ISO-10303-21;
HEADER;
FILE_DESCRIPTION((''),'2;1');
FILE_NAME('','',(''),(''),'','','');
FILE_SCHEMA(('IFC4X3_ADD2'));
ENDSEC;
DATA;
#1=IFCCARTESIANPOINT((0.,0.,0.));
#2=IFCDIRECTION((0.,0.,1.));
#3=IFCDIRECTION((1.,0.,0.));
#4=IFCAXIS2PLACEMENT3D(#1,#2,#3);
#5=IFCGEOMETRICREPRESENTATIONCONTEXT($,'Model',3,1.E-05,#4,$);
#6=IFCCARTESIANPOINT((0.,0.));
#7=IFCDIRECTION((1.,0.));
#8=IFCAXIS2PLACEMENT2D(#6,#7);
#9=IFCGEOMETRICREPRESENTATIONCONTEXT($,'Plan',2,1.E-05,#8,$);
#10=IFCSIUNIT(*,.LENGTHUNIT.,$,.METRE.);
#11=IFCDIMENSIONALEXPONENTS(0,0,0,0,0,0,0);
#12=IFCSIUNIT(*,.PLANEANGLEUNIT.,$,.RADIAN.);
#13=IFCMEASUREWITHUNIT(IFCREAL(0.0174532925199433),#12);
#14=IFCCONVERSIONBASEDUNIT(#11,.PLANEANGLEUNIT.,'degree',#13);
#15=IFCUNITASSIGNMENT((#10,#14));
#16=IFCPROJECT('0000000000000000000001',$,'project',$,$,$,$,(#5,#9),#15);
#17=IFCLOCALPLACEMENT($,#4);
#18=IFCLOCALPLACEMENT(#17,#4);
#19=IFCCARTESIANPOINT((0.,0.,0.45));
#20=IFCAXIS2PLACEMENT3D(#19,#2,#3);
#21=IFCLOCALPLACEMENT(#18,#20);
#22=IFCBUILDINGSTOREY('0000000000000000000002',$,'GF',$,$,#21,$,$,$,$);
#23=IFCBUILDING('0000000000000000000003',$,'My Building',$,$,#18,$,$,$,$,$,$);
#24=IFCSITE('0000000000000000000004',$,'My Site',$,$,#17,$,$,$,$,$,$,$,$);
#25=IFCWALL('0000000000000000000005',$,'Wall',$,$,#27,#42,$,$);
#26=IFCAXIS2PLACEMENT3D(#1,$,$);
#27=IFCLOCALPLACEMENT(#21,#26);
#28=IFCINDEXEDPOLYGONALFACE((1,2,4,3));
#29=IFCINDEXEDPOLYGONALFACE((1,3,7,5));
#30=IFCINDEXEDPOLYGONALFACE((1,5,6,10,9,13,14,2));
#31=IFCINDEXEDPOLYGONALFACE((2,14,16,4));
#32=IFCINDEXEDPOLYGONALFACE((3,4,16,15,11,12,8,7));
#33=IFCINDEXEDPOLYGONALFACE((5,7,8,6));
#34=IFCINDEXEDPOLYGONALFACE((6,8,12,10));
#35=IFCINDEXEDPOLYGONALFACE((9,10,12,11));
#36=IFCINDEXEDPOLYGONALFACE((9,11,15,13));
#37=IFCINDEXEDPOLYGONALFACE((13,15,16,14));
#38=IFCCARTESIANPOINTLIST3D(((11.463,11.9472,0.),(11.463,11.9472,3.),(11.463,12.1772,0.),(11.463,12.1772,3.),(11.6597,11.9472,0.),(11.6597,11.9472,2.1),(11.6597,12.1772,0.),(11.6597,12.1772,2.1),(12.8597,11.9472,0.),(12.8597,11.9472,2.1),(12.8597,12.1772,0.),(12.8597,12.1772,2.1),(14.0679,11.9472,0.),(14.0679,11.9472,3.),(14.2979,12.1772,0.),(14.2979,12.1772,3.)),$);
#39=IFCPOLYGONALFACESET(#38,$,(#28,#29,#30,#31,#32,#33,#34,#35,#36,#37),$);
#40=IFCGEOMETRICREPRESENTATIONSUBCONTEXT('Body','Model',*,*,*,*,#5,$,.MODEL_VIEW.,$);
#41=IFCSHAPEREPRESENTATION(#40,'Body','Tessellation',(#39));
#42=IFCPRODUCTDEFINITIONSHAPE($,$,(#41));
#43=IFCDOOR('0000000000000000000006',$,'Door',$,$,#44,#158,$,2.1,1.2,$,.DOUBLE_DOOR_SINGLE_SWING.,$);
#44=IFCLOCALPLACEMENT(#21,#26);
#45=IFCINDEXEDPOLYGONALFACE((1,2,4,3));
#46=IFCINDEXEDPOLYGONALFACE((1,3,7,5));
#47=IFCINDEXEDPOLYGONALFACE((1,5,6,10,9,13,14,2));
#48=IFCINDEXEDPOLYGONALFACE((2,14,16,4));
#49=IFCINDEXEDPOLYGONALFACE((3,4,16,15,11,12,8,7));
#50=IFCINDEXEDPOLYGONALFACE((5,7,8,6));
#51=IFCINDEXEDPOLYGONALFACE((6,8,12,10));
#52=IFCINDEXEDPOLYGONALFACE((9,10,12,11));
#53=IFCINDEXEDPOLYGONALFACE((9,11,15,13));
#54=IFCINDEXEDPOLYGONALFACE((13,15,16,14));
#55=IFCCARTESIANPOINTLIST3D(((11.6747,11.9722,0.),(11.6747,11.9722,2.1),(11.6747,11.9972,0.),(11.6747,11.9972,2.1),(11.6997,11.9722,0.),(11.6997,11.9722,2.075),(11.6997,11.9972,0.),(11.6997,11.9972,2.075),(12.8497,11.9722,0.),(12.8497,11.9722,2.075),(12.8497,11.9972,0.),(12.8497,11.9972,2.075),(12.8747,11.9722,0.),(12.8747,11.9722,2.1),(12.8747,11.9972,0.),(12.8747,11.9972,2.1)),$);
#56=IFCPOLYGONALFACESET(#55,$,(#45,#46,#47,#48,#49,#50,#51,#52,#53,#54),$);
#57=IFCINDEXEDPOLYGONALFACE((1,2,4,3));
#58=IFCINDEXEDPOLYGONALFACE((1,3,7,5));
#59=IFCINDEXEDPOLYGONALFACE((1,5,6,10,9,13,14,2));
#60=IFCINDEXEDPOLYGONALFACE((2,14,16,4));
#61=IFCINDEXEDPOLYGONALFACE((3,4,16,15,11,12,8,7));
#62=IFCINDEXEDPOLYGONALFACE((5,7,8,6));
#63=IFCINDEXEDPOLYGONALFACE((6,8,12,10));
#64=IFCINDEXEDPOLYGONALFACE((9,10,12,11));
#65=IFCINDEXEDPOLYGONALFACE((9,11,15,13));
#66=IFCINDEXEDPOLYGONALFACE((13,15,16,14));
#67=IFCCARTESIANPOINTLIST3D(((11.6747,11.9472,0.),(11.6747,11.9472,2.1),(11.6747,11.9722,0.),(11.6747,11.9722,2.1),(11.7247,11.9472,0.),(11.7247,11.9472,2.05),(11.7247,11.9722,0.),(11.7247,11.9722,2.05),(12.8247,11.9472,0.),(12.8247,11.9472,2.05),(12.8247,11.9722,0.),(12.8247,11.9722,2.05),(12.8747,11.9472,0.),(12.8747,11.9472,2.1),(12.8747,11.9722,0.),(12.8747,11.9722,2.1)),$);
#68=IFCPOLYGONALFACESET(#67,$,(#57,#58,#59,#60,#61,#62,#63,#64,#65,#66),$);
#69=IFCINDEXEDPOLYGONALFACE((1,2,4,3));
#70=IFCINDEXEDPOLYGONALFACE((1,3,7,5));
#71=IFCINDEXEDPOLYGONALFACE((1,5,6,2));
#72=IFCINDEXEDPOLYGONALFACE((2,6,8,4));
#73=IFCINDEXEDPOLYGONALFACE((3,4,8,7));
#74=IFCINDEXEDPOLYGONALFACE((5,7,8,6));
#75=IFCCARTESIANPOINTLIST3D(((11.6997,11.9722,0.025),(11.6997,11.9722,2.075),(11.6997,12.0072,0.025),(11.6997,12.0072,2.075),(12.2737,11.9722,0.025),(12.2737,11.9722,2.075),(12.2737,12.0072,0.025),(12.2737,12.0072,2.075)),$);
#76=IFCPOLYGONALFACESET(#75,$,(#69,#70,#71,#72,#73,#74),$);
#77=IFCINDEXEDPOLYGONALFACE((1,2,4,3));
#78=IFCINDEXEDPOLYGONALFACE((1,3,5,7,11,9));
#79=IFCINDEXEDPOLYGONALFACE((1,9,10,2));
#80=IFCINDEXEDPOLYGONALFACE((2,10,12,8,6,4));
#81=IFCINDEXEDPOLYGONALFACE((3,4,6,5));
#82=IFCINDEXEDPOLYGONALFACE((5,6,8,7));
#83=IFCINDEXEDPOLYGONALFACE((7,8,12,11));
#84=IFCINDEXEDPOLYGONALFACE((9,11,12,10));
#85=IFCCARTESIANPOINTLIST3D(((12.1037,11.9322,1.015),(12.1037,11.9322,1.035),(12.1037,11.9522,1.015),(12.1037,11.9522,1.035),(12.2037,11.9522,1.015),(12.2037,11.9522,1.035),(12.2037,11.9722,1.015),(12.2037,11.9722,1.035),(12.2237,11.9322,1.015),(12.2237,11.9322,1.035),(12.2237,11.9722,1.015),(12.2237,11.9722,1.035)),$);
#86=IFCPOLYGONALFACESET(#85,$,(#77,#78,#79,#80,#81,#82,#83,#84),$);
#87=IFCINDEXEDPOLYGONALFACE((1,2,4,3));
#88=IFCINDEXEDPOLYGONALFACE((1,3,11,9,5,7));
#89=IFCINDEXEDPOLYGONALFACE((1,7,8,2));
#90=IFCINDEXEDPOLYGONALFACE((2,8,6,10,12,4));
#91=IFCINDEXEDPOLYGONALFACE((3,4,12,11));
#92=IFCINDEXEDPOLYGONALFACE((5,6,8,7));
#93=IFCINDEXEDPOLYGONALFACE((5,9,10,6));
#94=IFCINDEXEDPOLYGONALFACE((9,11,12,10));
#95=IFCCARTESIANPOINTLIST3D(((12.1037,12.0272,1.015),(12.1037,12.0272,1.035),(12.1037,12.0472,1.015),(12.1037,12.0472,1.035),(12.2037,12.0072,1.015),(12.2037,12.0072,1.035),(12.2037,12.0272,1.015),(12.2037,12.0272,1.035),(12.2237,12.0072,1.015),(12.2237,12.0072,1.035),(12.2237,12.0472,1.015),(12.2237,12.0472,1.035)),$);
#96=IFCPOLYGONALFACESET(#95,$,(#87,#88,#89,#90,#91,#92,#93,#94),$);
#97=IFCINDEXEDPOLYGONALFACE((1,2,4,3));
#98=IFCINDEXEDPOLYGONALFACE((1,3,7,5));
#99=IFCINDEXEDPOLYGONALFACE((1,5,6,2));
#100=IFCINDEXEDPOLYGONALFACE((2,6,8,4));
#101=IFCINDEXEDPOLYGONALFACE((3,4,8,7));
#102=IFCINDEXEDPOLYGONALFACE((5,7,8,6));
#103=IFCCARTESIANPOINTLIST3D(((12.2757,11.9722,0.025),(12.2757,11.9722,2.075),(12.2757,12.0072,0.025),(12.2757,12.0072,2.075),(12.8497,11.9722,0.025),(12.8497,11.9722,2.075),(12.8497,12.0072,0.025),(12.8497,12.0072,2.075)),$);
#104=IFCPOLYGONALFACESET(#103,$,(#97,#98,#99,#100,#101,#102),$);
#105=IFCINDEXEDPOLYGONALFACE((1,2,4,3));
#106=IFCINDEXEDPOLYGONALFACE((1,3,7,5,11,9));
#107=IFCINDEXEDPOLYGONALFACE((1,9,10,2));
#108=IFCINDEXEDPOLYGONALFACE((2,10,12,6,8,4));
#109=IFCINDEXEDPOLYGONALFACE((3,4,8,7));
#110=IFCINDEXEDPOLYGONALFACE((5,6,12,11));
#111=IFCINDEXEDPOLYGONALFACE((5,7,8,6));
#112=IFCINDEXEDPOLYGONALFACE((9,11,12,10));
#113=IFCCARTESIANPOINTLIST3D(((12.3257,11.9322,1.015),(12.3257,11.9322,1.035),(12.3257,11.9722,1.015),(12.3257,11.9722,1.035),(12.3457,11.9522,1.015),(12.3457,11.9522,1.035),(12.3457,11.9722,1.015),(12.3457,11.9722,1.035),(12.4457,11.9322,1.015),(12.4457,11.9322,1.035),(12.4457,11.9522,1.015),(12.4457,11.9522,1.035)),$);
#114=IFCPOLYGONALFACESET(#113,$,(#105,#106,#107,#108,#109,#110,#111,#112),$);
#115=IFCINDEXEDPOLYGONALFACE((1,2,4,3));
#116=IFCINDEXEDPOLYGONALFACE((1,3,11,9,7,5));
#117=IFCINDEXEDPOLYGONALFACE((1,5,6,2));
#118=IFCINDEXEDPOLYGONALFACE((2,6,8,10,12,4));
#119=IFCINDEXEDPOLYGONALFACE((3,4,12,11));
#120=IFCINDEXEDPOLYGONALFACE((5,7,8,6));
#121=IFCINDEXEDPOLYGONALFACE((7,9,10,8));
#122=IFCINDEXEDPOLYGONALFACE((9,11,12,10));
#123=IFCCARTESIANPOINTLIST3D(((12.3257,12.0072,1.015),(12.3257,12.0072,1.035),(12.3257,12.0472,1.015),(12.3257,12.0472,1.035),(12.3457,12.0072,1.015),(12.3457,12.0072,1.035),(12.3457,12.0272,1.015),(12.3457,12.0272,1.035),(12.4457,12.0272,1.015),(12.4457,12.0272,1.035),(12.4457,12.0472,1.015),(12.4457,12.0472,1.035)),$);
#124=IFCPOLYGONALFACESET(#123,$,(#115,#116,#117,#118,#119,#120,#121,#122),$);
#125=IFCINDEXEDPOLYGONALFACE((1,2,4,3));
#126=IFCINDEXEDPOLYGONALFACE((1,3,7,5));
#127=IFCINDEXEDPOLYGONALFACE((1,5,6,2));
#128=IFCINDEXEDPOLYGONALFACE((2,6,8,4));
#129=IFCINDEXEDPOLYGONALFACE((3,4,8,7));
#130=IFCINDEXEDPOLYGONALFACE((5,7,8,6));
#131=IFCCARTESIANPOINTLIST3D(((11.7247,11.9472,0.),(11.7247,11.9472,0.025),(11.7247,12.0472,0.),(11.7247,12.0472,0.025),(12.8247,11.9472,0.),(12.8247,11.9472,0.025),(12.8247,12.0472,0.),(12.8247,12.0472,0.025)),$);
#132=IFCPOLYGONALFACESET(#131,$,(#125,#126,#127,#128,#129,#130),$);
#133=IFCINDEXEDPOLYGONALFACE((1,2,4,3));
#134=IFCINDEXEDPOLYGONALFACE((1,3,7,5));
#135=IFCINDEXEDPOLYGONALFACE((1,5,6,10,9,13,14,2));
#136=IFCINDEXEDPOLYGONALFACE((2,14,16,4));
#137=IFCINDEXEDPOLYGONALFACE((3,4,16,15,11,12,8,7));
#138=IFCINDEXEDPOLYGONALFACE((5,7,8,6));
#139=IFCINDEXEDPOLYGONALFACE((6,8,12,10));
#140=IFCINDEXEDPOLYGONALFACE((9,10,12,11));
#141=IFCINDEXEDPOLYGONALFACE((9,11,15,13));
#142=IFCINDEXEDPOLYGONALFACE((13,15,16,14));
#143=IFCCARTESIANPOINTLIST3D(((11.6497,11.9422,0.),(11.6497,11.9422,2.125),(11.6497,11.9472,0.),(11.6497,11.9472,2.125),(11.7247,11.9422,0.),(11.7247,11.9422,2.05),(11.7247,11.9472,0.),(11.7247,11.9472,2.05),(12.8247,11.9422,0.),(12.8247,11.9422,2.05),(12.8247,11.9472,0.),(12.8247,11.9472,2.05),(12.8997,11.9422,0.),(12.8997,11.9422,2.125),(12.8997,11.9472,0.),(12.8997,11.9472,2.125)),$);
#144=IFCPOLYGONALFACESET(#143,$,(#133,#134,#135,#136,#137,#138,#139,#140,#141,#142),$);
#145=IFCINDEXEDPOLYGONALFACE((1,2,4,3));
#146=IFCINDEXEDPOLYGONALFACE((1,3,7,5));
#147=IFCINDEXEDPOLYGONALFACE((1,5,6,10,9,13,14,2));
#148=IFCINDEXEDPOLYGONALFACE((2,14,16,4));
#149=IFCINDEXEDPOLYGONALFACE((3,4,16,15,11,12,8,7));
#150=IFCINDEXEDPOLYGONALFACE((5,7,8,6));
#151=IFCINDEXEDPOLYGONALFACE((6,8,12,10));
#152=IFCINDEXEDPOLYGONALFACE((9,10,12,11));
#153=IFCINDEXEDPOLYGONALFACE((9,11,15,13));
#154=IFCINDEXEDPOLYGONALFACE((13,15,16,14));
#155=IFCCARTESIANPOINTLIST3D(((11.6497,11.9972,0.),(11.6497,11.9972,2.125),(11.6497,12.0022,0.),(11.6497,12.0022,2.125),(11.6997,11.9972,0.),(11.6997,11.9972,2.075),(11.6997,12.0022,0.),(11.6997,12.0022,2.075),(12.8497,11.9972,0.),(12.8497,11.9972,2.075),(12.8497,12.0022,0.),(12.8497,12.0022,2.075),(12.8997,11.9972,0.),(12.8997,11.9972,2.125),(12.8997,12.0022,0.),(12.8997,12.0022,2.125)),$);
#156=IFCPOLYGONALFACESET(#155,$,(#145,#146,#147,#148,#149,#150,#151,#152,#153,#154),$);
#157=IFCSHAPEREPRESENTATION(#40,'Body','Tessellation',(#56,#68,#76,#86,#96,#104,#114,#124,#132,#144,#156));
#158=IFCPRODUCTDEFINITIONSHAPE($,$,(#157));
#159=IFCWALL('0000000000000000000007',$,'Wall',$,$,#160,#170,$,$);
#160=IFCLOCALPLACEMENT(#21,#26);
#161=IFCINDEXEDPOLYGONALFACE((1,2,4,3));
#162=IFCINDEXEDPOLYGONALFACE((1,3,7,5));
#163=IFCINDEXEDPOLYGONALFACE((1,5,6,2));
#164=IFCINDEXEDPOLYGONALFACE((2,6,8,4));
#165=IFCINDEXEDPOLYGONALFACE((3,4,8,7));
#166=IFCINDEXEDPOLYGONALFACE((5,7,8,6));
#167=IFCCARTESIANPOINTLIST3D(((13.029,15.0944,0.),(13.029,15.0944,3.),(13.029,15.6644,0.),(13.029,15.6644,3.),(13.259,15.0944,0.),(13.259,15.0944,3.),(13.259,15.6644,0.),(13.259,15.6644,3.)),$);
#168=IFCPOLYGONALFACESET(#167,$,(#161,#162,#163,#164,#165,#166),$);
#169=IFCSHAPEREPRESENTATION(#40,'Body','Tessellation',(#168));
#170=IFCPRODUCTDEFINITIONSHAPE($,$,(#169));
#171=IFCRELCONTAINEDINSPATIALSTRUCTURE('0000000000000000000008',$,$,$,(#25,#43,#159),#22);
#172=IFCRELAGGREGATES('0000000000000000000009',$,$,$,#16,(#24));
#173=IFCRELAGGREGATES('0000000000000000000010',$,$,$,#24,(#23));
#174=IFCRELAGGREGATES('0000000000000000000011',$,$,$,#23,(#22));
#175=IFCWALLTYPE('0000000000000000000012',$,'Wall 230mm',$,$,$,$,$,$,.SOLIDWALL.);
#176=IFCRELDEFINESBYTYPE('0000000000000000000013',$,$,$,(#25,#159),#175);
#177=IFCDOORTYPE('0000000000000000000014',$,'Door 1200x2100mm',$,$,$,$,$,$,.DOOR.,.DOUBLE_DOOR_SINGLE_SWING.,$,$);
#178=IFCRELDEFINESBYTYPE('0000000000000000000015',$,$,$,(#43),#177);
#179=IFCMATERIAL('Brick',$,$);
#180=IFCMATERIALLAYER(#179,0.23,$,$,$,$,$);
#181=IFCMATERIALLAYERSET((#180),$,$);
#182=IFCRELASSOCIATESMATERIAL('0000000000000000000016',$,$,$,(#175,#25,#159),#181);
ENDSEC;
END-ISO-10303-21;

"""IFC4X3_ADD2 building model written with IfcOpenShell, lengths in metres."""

from ifc_helpers import new_model, entity, si_unit, converted_unit, frame, origin_with_axes, origin_2d_with_axis, place, context, subcontext, project, spatial, line, indexed_curve, outline, extrude, clip, halfspace, shape, source, transform, mapped, material, layer, layer_set, layer_usage, type_object, type_shapes, element, fill, save


model = new_model("IFC4X3_ADD2")

# Units and contexts
model_context = context("Model", 3, precision=1e-05, world=origin_with_axes())
plan_context = context("Plan", 2, precision=1e-05, world=origin_2d_with_axis())
body_context_1 = subcontext(model_context, "Body", "Model", "MODEL_VIEW")
body_context_2 = subcontext(plan_context, "Body", "Plan", "PLAN_VIEW")
ifc_project = project(units=[si_unit("LENGTHUNIT", "METRE"), converted_unit("PLANEANGLEUNIT", "degree", entity("IfcReal", 0.0174532925199433), si_unit("PLANEANGLEUNIT", "RADIAN"), dimensions=[0, 0, 0, 0, 0, 0, 0])], contexts=[model_context, plan_context])

# Site, building, storey
site_placement = place(None, origin_with_axes())
site = spatial("IfcSite", under=ifc_project, at=site_placement, Name="My Site")
building_placement = place(site_placement, origin_with_axes())
building = spatial("IfcBuilding", under=site, at=building_placement, Name="My Building")
storey_placement = place(building_placement, frame((0.0, 0.0, 0.45), z_axis=(0.0, 0.0, 1.0), x_axis=(1.0, 0.0, 0.0)))
storey = spatial("IfcBuildingStorey", under=building, at=storey_placement, Name="GF")

# Shared definitions
ifc_material_1 = material(Name="Brick")
ifc_layer_1 = layer(ifc_material_1, 0.23)
ifc_layer_set_1 = layer_set([ifc_layer_1])
wall_type = type_object("IfcWallType", Name="Wall 230mm", PredefinedType="SOLIDWALL", material=ifc_layer_set_1)

# Wall, opening, door
ifc_layer_usage_1 = layer_usage(ifc_layer_set_1, "AXIS2", "POSITIVE", 0.0)
wall_1_placement = place(storey_placement, frame((11.463, 11.9472, 0.0), z_axis=(0.0, 0.0, 1.0), x_axis=(1.0, 0.0, 0.0)))
wall_1 = element("IfcWall", 1, at=wall_1_placement, inside=storey, type_object=wall_type, material=ifc_layer_usage_1, Name="Wall", context=body_context_1, shape_type="Clipping", body=[
    clip(extrude(outline(indexed_curve([(0.0, 0.0), (0.0, 0.23), (3.1602, 0.23), (3.1602, 0.0), (0.0, 0.0)], self_intersect=False)), origin_with_axes(), (0.0, 0.0, 1.0), 3.0), halfspace(frame((2.6049, 0.0, -0.45), z_axis=(0.689996, -0.689996, 0.0), x_axis=(-0.707107, -0.707107, 0.0)), False)),
])
shared_shape_1 = source(origin_with_axes(), body_context_1, "Body", "SweptSolid", [
    extrude(outline(indexed_curve([(0.0, 0.0), (1.2, 0.0), (1.2, 2.1), (0.0, 2.1)], segments=[line(1, 2, 3, 4, 1)])), frame((0.0, -0.6, 0.0), z_axis=(0.0, -1.0, 0.0), x_axis=(1.0, 0.0, 0.0)), (0.0, 0.0, -1.0), 1.2),
])
opening_1_placement = place(wall_1_placement, frame((0.1967, 0.0088, 0.0), z_axis=(0.0, 0.0, 1.0), x_axis=(1.0, 0.0, 0.0)))
opening_1 = element("IfcOpeningElement", 2, at=opening_1_placement, cuts=wall_1, PredefinedType="OPENING", context=body_context_1, shape_type="MappedRepresentation", body=[
    mapped(shared_shape_1, transform((0.0, 0.0, 0.0), x_axis=(1.0, 0.0, 0.0), y_axis=(0.0, 1.0, 0.0), z_axis=(0.0, 0.0, 1.0), scale=1.0)),
])
door_type_1 = type_object("IfcDoorType", Name="Door 1200x2100mm", OperationType="DOUBLE_DOOR_SINGLE_SWING", PredefinedType="DOOR")
shared_shape_2 = source(origin_with_axes(), body_context_1, "Body", "SweptSolid", [
    extrude(outline(indexed_curve([(0.0, 0.0), (0.0, 2.1), (1.2, 2.1), (1.2, 0.0), (1.175, 0.0), (1.175, 2.075), (0.025, 2.075), (0.025, 0.0)], segments=[line(1, 2, 3, 4, 5, 6, 7, 8, 1)])), frame((0.0, 0.025, 0.0), z_axis=(0.0, -1.0, 0.0), x_axis=(1.0, 0.0, 0.0)), (0.0, 0.0, -1.0), 0.025),
    extrude(outline(indexed_curve([(0.0, 0.0), (0.0, 2.1), (1.2, 2.1), (1.2, 0.0), (1.15, 0.0), (1.15, 2.05), (0.05, 2.05), (0.05, 0.0)], segments=[line(1, 2, 3, 4, 5, 6, 7, 8, 1)])), frame((0.0, 0.0, 0.0), z_axis=(0.0, -1.0, 0.0), x_axis=(1.0, 0.0, 0.0)), (0.0, 0.0, -1.0), 0.025),
    extrude(outline(indexed_curve([(0.0, 0.0), (0.574, 0.0), (0.574, 0.035), (0.0, 0.035)], segments=[line(1, 2, 3, 4, 1)])), frame((0.025, 0.025, 0.025), z_axis=(0.0, 0.0, 1.0), x_axis=(1.0, 0.0, 0.0)), (0.0, 0.0, 1.0), 2.05),
    extrude(outline(indexed_curve([(0.0, 0.0), (0.0, -0.04), (-0.12, -0.04), (-0.12, -0.02), (-0.02, -0.02), (-0.02, 0.0)], segments=[line(1, 2, 3, 4, 5, 6, 1)])), frame((0.549, 0.025, 1.015), z_axis=(0.0, 0.0, 1.0), x_axis=(1.0, 0.0, 0.0)), (0.0, 0.0, 1.0), 0.02),
    extrude(outline(indexed_curve([(0.0, 0.0), (0.0, 0.04), (-0.12, 0.04), (-0.12, 0.02), (-0.02, 0.02), (-0.02, 0.0)], segments=[line(1, 2, 3, 4, 5, 6, 1)])), frame((0.549, 0.06, 1.015), z_axis=(0.0, 0.0, 1.0), x_axis=(1.0, 0.0, 0.0)), (0.0, 0.0, 1.0), 0.02),
    extrude(outline(indexed_curve([(0.0, 0.0), (-0.574, 0.0), (-0.574, 0.035), (0.0, 0.035)], segments=[line(1, 2, 3, 4, 1)])), frame((1.175, 0.025, 0.025), z_axis=(0.0, 0.0, 1.0), x_axis=(1.0, 0.0, 0.0)), (0.0, 0.0, 1.0), 2.05),
    extrude(outline(indexed_curve([(0.0, 0.0), (0.0, -0.04), (0.12, -0.04), (0.12, -0.02), (0.02, -0.02), (0.02, 0.0)], segments=[line(1, 2, 3, 4, 5, 6, 1)])), frame((0.651, 0.025, 1.015), z_axis=(0.0, 0.0, 1.0), x_axis=(1.0, 0.0, 0.0)), (0.0, 0.0, 1.0), 0.02),
    extrude(outline(indexed_curve([(0.0, 0.0), (0.0, 0.04), (0.12, 0.04), (0.12, 0.02), (0.02, 0.02), (0.02, 0.0)], segments=[line(1, 2, 3, 4, 5, 6, 1)])), frame((0.651, 0.06, 1.015), z_axis=(0.0, 0.0, 1.0), x_axis=(1.0, 0.0, 0.0)), (0.0, 0.0, 1.0), 0.02),
    extrude(outline(indexed_curve([(0.0, 0.0), (1.1, 0.0), (1.1, 0.1), (0.0, 0.1)], segments=[line(1, 2, 3, 4, 1)])), frame((0.05, 0.0, 0.0), z_axis=(0.0, 0.0, 1.0), x_axis=(1.0, 0.0, 0.0)), (0.0, 0.0, 1.0), 0.025),
    extrude(outline(indexed_curve([(0.0, 0.0), (0.0, 2.125), (1.25, 2.125), (1.25, 0.0), (1.175, 0.0), (1.175, 2.05), (0.075, 2.05), (0.075, 0.0)], segments=[line(1, 2, 3, 4, 5, 6, 7, 8, 1)])), frame((-0.025, -0.005, 0.0), z_axis=(0.0, -1.0, 0.0), x_axis=(1.0, 0.0, 0.0)), (0.0, 0.0, -1.0), 0.005),
    extrude(outline(indexed_curve([(0.0, 0.0), (0.0, 2.125), (1.25, 2.125), (1.25, 0.0), (1.2, 0.0), (1.2, 2.075), (0.05, 2.075), (0.05, 0.0)], segments=[line(1, 2, 3, 4, 5, 6, 7, 8, 1)])), frame((-0.025, 0.05, 0.0), z_axis=(0.0, -1.0, 0.0), x_axis=(1.0, 0.0, 0.0)), (0.0, 0.0, -1.0), 0.005),
])
shared_shape_3 = source(origin_with_axes(), body_context_2, "Body", "Curve2D", [
    entity("IfcIndexedPolyCurve", entity("IfcCartesianPointList2D", [[0.0, 0.0], [0.0, 0.05], [0.025, 0.05], [0.025, 0.025], [0.05, 0.025], [0.05, 0.0]]), [entity("IfcLineIndex", [1, 2, 3, 4, 5, 6, 1])]),
    entity("IfcIndexedPolyCurve", entity("IfcCartesianPointList2D", [[1.2, 0.0], [1.2, 0.05], [1.175, 0.05], [1.175, 0.025], [1.15, 0.025], [1.15, 0.0]]), [entity("IfcLineIndex", [1, 2, 3, 4, 5, 6, 1])]),
    entity("IfcTrimmedCurve", entity("IfcEllipse", entity("IfcAxis2Placement2D", entity("IfcCartesianPoint", [0.06, 0.05]), entity("IfcDirection", [1.0, 0.0])), 0.54, 0.575), [entity("IfcCartesianPoint", [0.6, 0.05])], [entity("IfcCartesianPoint", [0.06, 0.625])], True, "CARTESIAN"),
    entity("IfcIndexedPolyCurve", entity("IfcCartesianPointList2D", [[0.025, 0.05], [0.06, 0.05], [0.06, 0.625], [0.025, 0.625]]), [entity("IfcLineIndex", [1, 2, 3, 4, 1])]),
    entity("IfcTrimmedCurve", entity("IfcEllipse", entity("IfcAxis2Placement2D", entity("IfcCartesianPoint", [1.14, 0.05]), entity("IfcDirection", [1.0, 0.0])), 0.54, 0.575), [entity("IfcCartesianPoint", [1.14, 0.625])], [entity("IfcCartesianPoint", [0.6, 0.05])], True, "CARTESIAN"),
    entity("IfcIndexedPolyCurve", entity("IfcCartesianPointList2D", [[1.175, 0.05], [1.14, 0.05], [1.14, 0.625], [1.175, 0.625]]), [entity("IfcLineIndex", [1, 2, 3, 4, 1])]),
])
type_shapes(door_type_1, [shared_shape_2, shared_shape_3])
door_1_placement = place(opening_1_placement, frame((0.015, -0.0088, 0.0), z_axis=(0.0, 0.0, 1.0), x_axis=(1.0, 0.0, 0.0)))
door_1 = element("IfcDoor", 3, at=door_1_placement, inside=storey, type_object=door_type_1, Name="Door", OperationType="DOUBLE_DOOR_SINGLE_SWING", OverallHeight=2.1, OverallWidth=1.2, shapes=[
    shape(body_context_1, "Body", "MappedRepresentation", [mapped(shared_shape_2, transform((0.0, 0.0, 0.0), x_axis=(1.0, 0.0, 0.0), y_axis=(0.0, 1.0, 0.0), z_axis=(0.0, 0.0, 1.0), scale=1.0))]),
    shape(body_context_2, "Body", "MappedRepresentation", [mapped(shared_shape_3, transform((0.0, 0.0, 0.0), x_axis=(1.0, 0.0, 0.0), y_axis=(0.0, 1.0, 0.0), z_axis=(0.0, 0.0, 1.0), scale=1.0))]),
])
fill(opening_1, door_1)

# Wall
ifc_layer_usage_2 = layer_usage(ifc_layer_set_1, "AXIS2", "POSITIVE", 0.0)
wall_2_placement = place(storey_placement, frame((13.259, 15.0944, 0.0), z_axis=(0.0, 0.0, 1.0), x_axis=(0.0, 1.0, 0.0)))
element("IfcWall", 4, at=wall_2_placement, inside=storey, type_object=wall_type, material=ifc_layer_usage_2, Name="Wall", context=body_context_1, shape_type="SweptSolid", body=[
    extrude(outline(indexed_curve([(0.0, 0.0), (0.0, 0.23), (0.57, 0.23), (0.57, 0.0), (0.0, 0.0)], self_intersect=False)), origin_with_axes(), (0.0, 0.0, 1.0), 3.0),
])

save(model, "model.ifc")
